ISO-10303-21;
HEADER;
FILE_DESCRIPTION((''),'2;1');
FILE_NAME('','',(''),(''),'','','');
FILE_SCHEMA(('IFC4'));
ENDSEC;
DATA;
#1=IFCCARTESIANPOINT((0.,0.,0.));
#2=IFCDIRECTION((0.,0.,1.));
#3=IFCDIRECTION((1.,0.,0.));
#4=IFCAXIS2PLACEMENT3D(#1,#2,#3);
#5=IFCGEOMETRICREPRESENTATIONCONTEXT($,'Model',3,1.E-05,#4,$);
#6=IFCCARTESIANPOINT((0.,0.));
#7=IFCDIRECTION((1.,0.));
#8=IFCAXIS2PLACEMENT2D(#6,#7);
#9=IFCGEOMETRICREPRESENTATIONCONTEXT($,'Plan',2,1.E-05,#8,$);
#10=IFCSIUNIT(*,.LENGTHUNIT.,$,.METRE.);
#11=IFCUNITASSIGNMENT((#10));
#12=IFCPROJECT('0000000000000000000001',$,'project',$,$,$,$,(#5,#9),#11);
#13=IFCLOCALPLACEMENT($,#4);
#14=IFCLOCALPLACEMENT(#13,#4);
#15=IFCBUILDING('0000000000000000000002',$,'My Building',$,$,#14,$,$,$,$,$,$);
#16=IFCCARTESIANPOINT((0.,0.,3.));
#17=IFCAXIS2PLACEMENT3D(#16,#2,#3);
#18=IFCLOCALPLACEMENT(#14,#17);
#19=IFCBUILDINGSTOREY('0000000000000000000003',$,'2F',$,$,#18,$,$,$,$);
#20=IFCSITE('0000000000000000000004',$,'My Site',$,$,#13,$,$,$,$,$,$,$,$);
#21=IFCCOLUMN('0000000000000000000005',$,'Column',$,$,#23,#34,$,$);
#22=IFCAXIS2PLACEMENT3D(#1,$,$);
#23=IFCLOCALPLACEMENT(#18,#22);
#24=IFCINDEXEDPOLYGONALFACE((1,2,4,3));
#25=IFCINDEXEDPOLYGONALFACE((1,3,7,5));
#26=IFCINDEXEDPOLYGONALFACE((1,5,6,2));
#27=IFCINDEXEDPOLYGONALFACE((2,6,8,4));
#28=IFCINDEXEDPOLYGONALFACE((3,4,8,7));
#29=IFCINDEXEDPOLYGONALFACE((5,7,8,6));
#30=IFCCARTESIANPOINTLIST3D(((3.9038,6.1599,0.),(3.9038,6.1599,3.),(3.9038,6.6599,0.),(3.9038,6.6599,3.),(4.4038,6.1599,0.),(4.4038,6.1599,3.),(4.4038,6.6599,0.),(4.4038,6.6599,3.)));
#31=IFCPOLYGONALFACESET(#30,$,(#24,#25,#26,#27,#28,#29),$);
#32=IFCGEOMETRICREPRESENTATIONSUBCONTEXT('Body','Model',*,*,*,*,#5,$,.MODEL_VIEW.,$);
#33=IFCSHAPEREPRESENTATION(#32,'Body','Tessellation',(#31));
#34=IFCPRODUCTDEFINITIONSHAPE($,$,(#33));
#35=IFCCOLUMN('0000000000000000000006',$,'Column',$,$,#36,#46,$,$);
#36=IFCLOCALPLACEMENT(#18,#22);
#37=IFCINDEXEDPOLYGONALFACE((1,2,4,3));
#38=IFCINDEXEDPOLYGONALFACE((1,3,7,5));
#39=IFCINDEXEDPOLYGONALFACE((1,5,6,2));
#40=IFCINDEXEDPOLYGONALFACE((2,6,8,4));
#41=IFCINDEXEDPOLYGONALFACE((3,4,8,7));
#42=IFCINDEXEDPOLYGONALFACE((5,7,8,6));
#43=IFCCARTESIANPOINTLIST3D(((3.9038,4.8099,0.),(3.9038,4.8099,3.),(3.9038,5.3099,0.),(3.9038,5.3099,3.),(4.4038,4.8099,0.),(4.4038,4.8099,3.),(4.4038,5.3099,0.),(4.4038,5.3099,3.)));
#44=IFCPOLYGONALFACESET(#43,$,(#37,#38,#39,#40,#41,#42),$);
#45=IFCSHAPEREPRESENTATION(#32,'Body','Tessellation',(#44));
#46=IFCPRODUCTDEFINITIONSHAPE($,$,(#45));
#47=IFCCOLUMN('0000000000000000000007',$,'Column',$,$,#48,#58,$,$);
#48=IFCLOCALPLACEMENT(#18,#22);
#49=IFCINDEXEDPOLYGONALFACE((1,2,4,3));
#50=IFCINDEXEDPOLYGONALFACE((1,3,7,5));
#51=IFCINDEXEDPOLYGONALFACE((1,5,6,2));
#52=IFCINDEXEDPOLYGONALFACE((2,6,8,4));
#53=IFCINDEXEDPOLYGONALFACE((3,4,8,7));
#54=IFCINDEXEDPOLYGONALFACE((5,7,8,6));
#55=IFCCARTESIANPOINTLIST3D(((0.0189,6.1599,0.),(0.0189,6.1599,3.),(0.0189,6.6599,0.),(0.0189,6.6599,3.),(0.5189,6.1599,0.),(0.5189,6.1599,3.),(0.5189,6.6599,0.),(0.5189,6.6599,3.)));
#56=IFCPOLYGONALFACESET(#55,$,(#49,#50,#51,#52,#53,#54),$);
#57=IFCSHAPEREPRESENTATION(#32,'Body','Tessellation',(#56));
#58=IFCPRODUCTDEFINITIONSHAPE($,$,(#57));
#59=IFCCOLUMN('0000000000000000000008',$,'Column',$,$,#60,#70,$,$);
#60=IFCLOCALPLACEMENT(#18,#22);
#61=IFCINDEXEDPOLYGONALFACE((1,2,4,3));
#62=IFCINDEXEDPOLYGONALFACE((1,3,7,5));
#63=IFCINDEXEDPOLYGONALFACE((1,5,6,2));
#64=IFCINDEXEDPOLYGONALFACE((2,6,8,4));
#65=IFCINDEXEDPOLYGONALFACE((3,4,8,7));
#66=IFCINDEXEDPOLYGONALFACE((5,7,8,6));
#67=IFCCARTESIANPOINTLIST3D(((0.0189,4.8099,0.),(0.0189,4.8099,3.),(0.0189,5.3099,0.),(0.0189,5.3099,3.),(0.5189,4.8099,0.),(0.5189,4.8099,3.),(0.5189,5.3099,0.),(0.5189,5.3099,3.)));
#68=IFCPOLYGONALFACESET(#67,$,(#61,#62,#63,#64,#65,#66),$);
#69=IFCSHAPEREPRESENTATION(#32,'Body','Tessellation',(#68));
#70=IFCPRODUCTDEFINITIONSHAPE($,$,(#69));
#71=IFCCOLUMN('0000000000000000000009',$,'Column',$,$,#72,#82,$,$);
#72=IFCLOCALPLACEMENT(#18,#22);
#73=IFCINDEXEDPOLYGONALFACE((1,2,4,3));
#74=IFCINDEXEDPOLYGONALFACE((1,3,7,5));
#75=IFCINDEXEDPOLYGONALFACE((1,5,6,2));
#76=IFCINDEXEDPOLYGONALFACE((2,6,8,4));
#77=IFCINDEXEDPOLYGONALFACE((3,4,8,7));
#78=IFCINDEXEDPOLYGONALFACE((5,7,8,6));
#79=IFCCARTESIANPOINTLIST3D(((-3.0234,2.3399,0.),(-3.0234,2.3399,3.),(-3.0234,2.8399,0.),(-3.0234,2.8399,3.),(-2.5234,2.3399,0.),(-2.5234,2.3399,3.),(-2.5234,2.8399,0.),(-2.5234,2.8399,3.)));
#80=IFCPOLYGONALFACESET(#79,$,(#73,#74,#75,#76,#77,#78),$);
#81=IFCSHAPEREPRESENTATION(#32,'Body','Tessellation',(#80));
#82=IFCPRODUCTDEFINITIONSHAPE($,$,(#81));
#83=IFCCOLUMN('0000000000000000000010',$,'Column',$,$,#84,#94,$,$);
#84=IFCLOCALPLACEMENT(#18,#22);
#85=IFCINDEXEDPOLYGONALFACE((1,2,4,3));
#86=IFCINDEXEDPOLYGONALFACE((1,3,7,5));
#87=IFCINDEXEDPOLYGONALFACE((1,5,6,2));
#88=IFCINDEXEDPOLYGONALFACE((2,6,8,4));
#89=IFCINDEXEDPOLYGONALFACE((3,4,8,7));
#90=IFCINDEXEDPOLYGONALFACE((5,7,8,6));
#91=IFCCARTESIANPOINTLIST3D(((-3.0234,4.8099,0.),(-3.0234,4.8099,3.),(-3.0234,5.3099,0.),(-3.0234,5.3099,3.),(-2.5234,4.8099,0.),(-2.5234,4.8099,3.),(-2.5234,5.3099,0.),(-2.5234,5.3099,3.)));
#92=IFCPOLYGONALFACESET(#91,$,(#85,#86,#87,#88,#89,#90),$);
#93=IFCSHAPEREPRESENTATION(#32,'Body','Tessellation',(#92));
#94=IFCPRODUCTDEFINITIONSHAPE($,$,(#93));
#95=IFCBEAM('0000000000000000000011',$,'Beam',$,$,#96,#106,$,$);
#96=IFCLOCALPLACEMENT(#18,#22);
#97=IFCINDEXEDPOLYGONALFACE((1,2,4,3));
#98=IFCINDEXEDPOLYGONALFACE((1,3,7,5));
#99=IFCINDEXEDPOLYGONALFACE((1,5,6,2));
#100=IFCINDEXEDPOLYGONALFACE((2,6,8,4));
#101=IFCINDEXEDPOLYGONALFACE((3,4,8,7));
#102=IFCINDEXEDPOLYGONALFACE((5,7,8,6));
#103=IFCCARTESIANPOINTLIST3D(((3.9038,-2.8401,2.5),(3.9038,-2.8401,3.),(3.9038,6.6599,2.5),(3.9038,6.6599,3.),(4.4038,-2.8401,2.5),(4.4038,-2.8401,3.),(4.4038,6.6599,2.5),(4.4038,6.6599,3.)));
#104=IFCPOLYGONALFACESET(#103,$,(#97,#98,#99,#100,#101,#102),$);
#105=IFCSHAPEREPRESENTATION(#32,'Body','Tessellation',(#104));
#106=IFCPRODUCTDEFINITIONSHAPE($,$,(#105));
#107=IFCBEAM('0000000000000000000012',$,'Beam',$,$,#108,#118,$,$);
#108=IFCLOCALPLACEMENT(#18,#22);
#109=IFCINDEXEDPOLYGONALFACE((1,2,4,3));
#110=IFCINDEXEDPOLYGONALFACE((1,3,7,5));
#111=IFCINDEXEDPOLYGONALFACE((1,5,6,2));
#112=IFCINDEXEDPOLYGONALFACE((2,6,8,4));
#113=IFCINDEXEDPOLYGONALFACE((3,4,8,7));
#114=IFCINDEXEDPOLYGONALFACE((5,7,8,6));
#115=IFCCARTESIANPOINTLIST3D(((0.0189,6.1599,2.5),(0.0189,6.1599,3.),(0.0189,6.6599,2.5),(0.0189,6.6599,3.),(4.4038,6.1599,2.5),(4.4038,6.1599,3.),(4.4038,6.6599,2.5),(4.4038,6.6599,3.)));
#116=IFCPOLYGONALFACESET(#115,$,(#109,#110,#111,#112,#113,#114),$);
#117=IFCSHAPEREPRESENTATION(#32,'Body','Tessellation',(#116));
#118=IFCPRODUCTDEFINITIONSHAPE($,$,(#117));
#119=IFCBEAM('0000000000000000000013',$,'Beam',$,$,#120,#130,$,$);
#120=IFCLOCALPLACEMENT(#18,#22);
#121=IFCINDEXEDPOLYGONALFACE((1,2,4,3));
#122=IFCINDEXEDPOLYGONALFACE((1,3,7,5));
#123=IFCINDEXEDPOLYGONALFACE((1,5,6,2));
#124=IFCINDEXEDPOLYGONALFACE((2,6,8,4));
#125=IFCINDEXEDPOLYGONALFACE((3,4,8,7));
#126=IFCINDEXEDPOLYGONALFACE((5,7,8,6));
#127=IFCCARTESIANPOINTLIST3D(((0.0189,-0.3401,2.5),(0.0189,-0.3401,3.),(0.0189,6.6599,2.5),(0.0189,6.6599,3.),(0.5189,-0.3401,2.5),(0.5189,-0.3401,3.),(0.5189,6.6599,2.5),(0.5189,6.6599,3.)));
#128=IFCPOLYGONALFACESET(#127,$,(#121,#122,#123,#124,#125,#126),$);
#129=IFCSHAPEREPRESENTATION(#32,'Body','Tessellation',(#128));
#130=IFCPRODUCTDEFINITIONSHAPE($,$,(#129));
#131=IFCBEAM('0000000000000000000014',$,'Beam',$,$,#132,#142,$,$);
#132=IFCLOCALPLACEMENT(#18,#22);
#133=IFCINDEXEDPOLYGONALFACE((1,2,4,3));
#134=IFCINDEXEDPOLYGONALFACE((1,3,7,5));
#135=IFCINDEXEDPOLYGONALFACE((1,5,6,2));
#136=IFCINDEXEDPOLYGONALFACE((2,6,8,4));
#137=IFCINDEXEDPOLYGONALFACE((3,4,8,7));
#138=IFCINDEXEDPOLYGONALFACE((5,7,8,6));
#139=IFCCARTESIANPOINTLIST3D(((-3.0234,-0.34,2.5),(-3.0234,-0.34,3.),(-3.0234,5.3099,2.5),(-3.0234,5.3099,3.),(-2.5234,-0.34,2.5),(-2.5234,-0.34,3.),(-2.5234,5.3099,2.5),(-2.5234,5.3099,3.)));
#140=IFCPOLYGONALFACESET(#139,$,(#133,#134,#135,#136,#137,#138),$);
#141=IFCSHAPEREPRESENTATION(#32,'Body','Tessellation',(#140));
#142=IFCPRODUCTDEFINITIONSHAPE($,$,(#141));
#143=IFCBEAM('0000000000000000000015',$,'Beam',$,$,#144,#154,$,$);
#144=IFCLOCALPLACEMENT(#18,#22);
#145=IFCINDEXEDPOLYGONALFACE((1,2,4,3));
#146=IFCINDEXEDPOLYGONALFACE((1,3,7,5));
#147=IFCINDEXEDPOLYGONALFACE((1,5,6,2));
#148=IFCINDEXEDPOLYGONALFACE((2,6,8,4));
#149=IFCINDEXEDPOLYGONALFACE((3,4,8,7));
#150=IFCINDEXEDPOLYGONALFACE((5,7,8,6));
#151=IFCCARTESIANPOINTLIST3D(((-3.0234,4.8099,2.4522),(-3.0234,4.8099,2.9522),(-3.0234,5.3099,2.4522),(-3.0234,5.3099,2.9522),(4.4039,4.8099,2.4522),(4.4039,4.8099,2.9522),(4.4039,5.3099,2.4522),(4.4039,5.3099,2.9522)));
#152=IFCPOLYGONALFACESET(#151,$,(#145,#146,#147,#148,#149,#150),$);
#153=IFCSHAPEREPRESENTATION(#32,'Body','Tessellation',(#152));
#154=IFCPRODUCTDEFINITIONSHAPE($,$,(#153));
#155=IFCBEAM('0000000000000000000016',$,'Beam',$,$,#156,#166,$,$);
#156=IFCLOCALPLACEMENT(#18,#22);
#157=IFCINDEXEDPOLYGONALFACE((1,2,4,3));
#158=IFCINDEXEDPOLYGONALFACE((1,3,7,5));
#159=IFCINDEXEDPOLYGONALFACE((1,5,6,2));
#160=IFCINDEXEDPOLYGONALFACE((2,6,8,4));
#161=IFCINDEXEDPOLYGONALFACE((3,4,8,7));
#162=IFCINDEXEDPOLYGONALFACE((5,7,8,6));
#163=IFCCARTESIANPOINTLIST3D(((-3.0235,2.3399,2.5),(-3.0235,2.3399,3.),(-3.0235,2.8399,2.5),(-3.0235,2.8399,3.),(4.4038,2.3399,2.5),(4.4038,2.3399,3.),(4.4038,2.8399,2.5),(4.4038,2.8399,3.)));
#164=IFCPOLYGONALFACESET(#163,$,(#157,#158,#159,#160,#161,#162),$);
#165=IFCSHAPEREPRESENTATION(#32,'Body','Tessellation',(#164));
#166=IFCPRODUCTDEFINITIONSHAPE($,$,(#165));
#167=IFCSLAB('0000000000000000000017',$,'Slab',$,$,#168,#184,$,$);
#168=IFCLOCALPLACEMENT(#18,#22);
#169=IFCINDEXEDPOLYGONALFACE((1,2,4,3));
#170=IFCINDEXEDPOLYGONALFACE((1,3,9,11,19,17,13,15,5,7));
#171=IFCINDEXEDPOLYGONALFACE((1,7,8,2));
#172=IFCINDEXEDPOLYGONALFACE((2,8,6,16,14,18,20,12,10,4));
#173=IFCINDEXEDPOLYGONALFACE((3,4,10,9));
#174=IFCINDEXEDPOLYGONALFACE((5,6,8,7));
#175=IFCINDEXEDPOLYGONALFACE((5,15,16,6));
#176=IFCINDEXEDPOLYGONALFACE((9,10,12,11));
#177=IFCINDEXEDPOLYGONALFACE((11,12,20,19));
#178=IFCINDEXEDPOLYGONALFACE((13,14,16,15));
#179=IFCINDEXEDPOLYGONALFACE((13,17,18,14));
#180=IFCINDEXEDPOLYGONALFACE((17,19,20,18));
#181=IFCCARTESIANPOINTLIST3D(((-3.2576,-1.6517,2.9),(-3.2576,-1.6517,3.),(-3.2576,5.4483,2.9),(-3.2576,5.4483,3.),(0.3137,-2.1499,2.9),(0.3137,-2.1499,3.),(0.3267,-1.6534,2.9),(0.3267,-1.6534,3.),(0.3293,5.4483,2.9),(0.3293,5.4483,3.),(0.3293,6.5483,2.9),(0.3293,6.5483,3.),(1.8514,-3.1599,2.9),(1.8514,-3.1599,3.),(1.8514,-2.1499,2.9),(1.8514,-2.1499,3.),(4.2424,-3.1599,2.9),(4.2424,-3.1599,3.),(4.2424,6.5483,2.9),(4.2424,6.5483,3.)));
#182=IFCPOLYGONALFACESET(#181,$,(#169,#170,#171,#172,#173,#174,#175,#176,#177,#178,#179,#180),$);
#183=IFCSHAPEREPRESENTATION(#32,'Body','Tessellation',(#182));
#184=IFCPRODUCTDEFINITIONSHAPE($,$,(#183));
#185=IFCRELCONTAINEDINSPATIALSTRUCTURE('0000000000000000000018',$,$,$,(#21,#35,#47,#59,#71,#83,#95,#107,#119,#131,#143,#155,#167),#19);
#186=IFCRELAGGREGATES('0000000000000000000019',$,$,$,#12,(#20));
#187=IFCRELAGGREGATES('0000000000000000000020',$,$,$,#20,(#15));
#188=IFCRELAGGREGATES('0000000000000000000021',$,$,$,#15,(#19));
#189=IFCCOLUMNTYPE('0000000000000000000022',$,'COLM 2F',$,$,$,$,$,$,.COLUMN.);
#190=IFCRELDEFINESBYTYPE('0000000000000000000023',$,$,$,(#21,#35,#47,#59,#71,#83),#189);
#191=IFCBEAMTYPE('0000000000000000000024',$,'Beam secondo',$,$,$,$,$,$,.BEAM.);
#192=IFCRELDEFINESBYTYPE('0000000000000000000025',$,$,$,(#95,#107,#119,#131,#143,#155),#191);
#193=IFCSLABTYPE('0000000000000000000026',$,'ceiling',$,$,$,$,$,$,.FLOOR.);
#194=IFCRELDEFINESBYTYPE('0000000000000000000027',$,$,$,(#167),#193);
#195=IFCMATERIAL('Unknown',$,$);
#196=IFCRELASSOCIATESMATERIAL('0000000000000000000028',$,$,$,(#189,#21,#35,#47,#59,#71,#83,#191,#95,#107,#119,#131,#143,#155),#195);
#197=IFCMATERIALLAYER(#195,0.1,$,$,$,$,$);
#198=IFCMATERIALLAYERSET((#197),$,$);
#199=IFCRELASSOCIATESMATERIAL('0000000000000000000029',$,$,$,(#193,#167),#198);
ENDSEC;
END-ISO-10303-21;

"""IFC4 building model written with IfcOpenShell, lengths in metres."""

from ifc_helpers import new_model, si_unit, frame, origin_with_axes, origin_2d_with_axis, place, context, subcontext, project, spatial, indexed_curve, rectangle, outline, extrude, material, layer, layer_set, layer_usage, material_profile, profile_set, profile_usage, type_object, element, save


model = new_model("IFC4")

# Units and contexts
model_context = context("Model", 3, precision=1e-05, world=origin_with_axes())
plan_context = context("Plan", 2, precision=1e-05, world=origin_2d_with_axis())
body_context_1 = subcontext(model_context, "Body", "Model", "MODEL_VIEW")
ifc_project = project(units=[si_unit("LENGTHUNIT", "METRE")], contexts=[model_context, plan_context])

# Site, building, storey
site_placement = place(None, origin_with_axes())
site = spatial("IfcSite", under=ifc_project, at=site_placement, Name="My Site")
building_placement = place(site_placement, origin_with_axes())
building = spatial("IfcBuilding", under=site, at=building_placement, Name="My Building")
storey_placement = place(building_placement, frame((0.0, 0.0, 3.0), z_axis=(0.0, 0.0, 1.0), x_axis=(1.0, 0.0, 0.0)))
storey = spatial("IfcBuildingStorey", under=building, at=storey_placement, Name="2F")

# Columns
ifc_material = material(Name="Unknown")
ifc_material_profile_1 = material_profile(ifc_material, rectangle(XDim=0.5, YDim=0.5))
ifc_profile_set_1 = profile_set([ifc_material_profile_1])
ifc_profile_usage_1 = profile_usage(ifc_profile_set_1, cardinal=5)
column_type = type_object("IfcColumnType", Name="COLM 2F", PredefinedType="COLUMN", material=ifc_profile_set_1)
column_1_placement = place(storey_placement, frame((4.1538, 6.4099, 0.0), z_axis=(0.0, 0.0, 1.0), x_axis=(1.0, 0.0, 0.0)))
element("IfcColumn", 1, at=column_1_placement, inside=storey, type_object=column_type, material=ifc_profile_usage_1, Name="Column", context=body_context_1, shape_type="SweptSolid", body=[
    extrude(rectangle(XDim=0.5, YDim=0.5), origin_with_axes(), (0.0, 0.0, 1.0), 3.0),
])
ifc_profile_usage_2 = profile_usage(ifc_profile_set_1, cardinal=5)
column_2_placement = place(storey_placement, frame((4.1538, 5.0599, 0.0), z_axis=(0.0, 0.0, 1.0), x_axis=(1.0, 0.0, 0.0)))
element("IfcColumn", 2, at=column_2_placement, inside=storey, type_object=column_type, material=ifc_profile_usage_2, Name="Column", context=body_context_1, shape_type="SweptSolid", body=[
    extrude(rectangle(XDim=0.5, YDim=0.5), origin_with_axes(), (0.0, 0.0, 1.0), 3.0),
])
ifc_profile_usage_3 = profile_usage(ifc_profile_set_1, cardinal=5)
column_3_placement = place(storey_placement, frame((0.2689, 6.4099, 0.0), z_axis=(0.0, 0.0, 1.0), x_axis=(1.0, 0.0, 0.0)))
element("IfcColumn", 3, at=column_3_placement, inside=storey, type_object=column_type, material=ifc_profile_usage_3, Name="Column", context=body_context_1, shape_type="SweptSolid", body=[
    extrude(rectangle(XDim=0.5, YDim=0.5), origin_with_axes(), (0.0, 0.0, 1.0), 3.0),
])
ifc_profile_usage_4 = profile_usage(ifc_profile_set_1, cardinal=5)
column_4_placement = place(storey_placement, frame((0.2689, 5.0599, 0.0), z_axis=(0.0, 0.0, 1.0), x_axis=(1.0, 0.0, 0.0)))
element("IfcColumn", 4, at=column_4_placement, inside=storey, type_object=column_type, material=ifc_profile_usage_4, Name="Column", context=body_context_1, shape_type="SweptSolid", body=[
    extrude(rectangle(XDim=0.5, YDim=0.5), origin_with_axes(), (0.0, 0.0, 1.0), 3.0),
])
ifc_profile_usage_5 = profile_usage(ifc_profile_set_1, cardinal=5)
column_5_placement = place(storey_placement, frame((-2.7734, 2.5899, 0.0), z_axis=(0.0, 0.0, 1.0), x_axis=(1.0, 0.0, 0.0)))
element("IfcColumn", 5, at=column_5_placement, inside=storey, type_object=column_type, material=ifc_profile_usage_5, Name="Column", context=body_context_1, shape_type="SweptSolid", body=[
    extrude(rectangle(XDim=0.5, YDim=0.5), origin_with_axes(), (0.0, 0.0, 1.0), 3.0),
])
ifc_profile_usage_6 = profile_usage(ifc_profile_set_1, cardinal=5)
column_6_placement = place(storey_placement, frame((-2.7734, 5.0599, 0.0), z_axis=(0.0, 0.0, 1.0), x_axis=(1.0, 0.0, 0.0)))
element("IfcColumn", 6, at=column_6_placement, inside=storey, type_object=column_type, material=ifc_profile_usage_6, Name="Column", context=body_context_1, shape_type="SweptSolid", body=[
    extrude(rectangle(XDim=0.5, YDim=0.5), origin_with_axes(), (0.0, 0.0, 1.0), 3.0),
])

# Beams
ifc_material_profile_2 = material_profile(ifc_material, rectangle(XDim=0.5, YDim=0.5))
ifc_profile_set_2 = profile_set([ifc_material_profile_2])
ifc_profile_usage_7 = profile_usage(ifc_profile_set_2, cardinal=7)
beam_type = type_object("IfcBeamType", Name="Beam secondo", PredefinedType="BEAM", material=ifc_profile_set_2)
beam_1_placement = place(storey_placement, frame((4.4038, 6.6599, 3.0), z_axis=(0.0, -1.0, 0.0), x_axis=(1.0, 0.0, 0.0)))
element("IfcBeam", 7, at=beam_1_placement, inside=storey, type_object=beam_type, material=ifc_profile_usage_7, Name="Beam", context=body_context_1, shape_type="SweptSolid", body=[
    extrude(rectangle(XDim=0.5, YDim=0.5), frame((-0.25, -0.25, 0.0), z_axis=(0.0, 0.0, 1.0), x_axis=(1.0, 0.0, 0.0)), (0.0, 0.0, 1.0), 9.5),
])
ifc_profile_usage_8 = profile_usage(ifc_profile_set_2, cardinal=7)
beam_2_placement = place(storey_placement, frame((4.4038, 6.1599, 3.0), z_axis=(-1.0, 0.0, 0.0), x_axis=(0.0, -1.0, 0.0)))
element("IfcBeam", 8, at=beam_2_placement, inside=storey, type_object=beam_type, material=ifc_profile_usage_8, Name="Beam", context=body_context_1, shape_type="SweptSolid", body=[
    extrude(rectangle(XDim=0.5, YDim=0.5), frame((-0.25, -0.25, 0.0), z_axis=(0.0, 0.0, 1.0), x_axis=(1.0, 0.0, 0.0)), (0.0, 0.0, 1.0), 4.3849),
])
ifc_profile_usage_9 = profile_usage(ifc_profile_set_2, cardinal=7)
beam_3_placement = place(storey_placement, frame((0.5189, 6.6599, 3.0), z_axis=(0.0, -1.0, 0.0), x_axis=(1.0, 0.0, 0.0)))
element("IfcBeam", 9, at=beam_3_placement, inside=storey, type_object=beam_type, material=ifc_profile_usage_9, Name="Beam", context=body_context_1, shape_type="SweptSolid", body=[
    extrude(rectangle(XDim=0.5, YDim=0.5), frame((-0.25, -0.25, 0.0), z_axis=(0.0, 0.0, 1.0), x_axis=(1.0, 0.0, 0.0)), (0.0, 0.0, 1.0), 7.0),
])
ifc_profile_usage_10 = profile_usage(ifc_profile_set_2, cardinal=7)
beam_4_placement = place(storey_placement, frame((-2.5234, 5.3099, 3.0), z_axis=(0.0, -1.0, 0.0), x_axis=(1.0, 0.0, 0.0)))
element("IfcBeam", 10, at=beam_4_placement, inside=storey, type_object=beam_type, material=ifc_profile_usage_10, Name="Beam", context=body_context_1, shape_type="SweptSolid", body=[
    extrude(rectangle(XDim=0.5, YDim=0.5), frame((-0.25, -0.25, 0.0), z_axis=(0.0, 0.0, 1.0), x_axis=(1.0, 0.0, 0.0)), (0.0, 0.0, 1.0), 5.6499),
])
ifc_profile_usage_11 = profile_usage(ifc_profile_set_2, cardinal=7)
beam_5_placement = place(storey_placement, frame((-3.0234, 5.3099, 2.9522), z_axis=(1.0, 0.0, 0.0), x_axis=(0.0, 1.0, 0.0)))
element("IfcBeam", 11, at=beam_5_placement, inside=storey, type_object=beam_type, material=ifc_profile_usage_11, Name="Beam", context=body_context_1, shape_type="SweptSolid", body=[
    extrude(rectangle(XDim=0.5, YDim=0.5), frame((-0.25, -0.25, 0.0), z_axis=(0.0, 0.0, 1.0), x_axis=(1.0, 0.0, 0.0)), (0.0, 0.0, 1.0), 7.4273),
])
ifc_profile_usage_12 = profile_usage(ifc_profile_set_2, cardinal=7)
beam_6_placement = place(storey_placement, frame((-3.0235, 2.8399, 3.0), z_axis=(1.0, 0.0, 0.0), x_axis=(0.0, 1.0, 0.0)))
element("IfcBeam", 12, at=beam_6_placement, inside=storey, type_object=beam_type, material=ifc_profile_usage_12, Name="Beam", context=body_context_1, shape_type="SweptSolid", body=[
    extrude(rectangle(XDim=0.5, YDim=0.5), frame((-0.25, -0.25, 0.0), z_axis=(0.0, 0.0, 1.0), x_axis=(1.0, 0.0, 0.0)), (0.0, 0.0, 1.0), 7.4273),
])

# Slab
ifc_layer_1 = layer(ifc_material, 0.1)
ifc_layer_set_1 = layer_set([ifc_layer_1])
ifc_layer_usage_1 = layer_usage(ifc_layer_set_1, "AXIS3", "POSITIVE", -0.1)
slab_type = type_object("IfcSlabType", Name="ceiling", PredefinedType="FLOOR", material=ifc_layer_set_1)
slab_placement = place(storey_placement, frame((-3.2576, 5.4483, 3.0), z_axis=(0.0, 0.0, 1.0), x_axis=(1.0, 0.0, 0.0)))
element("IfcSlab", 13, at=slab_placement, inside=storey, type_object=slab_type, material=ifc_layer_usage_1, Name="Slab", context=body_context_1, shape_type="SweptSolid", body=[
    extrude(outline(indexed_curve([(0.0, 0.0), (0.0, -7.1), (3.5843, -7.1017), (3.5713, -7.5982), (5.109, -7.5982), (5.109, -8.6082), (7.5, -8.6082), (7.5, 1.1), (3.5869, 1.1), (3.5869, 0.0), (0.0, 0.0)])), frame((0.0, 0.0, -0.1), z_axis=(0.0, 0.0, 1.0), x_axis=(1.0, 0.0, 0.0)), (0.0, 0.0, 1.0), 0.1),
])

save(model, "model.ifc")
